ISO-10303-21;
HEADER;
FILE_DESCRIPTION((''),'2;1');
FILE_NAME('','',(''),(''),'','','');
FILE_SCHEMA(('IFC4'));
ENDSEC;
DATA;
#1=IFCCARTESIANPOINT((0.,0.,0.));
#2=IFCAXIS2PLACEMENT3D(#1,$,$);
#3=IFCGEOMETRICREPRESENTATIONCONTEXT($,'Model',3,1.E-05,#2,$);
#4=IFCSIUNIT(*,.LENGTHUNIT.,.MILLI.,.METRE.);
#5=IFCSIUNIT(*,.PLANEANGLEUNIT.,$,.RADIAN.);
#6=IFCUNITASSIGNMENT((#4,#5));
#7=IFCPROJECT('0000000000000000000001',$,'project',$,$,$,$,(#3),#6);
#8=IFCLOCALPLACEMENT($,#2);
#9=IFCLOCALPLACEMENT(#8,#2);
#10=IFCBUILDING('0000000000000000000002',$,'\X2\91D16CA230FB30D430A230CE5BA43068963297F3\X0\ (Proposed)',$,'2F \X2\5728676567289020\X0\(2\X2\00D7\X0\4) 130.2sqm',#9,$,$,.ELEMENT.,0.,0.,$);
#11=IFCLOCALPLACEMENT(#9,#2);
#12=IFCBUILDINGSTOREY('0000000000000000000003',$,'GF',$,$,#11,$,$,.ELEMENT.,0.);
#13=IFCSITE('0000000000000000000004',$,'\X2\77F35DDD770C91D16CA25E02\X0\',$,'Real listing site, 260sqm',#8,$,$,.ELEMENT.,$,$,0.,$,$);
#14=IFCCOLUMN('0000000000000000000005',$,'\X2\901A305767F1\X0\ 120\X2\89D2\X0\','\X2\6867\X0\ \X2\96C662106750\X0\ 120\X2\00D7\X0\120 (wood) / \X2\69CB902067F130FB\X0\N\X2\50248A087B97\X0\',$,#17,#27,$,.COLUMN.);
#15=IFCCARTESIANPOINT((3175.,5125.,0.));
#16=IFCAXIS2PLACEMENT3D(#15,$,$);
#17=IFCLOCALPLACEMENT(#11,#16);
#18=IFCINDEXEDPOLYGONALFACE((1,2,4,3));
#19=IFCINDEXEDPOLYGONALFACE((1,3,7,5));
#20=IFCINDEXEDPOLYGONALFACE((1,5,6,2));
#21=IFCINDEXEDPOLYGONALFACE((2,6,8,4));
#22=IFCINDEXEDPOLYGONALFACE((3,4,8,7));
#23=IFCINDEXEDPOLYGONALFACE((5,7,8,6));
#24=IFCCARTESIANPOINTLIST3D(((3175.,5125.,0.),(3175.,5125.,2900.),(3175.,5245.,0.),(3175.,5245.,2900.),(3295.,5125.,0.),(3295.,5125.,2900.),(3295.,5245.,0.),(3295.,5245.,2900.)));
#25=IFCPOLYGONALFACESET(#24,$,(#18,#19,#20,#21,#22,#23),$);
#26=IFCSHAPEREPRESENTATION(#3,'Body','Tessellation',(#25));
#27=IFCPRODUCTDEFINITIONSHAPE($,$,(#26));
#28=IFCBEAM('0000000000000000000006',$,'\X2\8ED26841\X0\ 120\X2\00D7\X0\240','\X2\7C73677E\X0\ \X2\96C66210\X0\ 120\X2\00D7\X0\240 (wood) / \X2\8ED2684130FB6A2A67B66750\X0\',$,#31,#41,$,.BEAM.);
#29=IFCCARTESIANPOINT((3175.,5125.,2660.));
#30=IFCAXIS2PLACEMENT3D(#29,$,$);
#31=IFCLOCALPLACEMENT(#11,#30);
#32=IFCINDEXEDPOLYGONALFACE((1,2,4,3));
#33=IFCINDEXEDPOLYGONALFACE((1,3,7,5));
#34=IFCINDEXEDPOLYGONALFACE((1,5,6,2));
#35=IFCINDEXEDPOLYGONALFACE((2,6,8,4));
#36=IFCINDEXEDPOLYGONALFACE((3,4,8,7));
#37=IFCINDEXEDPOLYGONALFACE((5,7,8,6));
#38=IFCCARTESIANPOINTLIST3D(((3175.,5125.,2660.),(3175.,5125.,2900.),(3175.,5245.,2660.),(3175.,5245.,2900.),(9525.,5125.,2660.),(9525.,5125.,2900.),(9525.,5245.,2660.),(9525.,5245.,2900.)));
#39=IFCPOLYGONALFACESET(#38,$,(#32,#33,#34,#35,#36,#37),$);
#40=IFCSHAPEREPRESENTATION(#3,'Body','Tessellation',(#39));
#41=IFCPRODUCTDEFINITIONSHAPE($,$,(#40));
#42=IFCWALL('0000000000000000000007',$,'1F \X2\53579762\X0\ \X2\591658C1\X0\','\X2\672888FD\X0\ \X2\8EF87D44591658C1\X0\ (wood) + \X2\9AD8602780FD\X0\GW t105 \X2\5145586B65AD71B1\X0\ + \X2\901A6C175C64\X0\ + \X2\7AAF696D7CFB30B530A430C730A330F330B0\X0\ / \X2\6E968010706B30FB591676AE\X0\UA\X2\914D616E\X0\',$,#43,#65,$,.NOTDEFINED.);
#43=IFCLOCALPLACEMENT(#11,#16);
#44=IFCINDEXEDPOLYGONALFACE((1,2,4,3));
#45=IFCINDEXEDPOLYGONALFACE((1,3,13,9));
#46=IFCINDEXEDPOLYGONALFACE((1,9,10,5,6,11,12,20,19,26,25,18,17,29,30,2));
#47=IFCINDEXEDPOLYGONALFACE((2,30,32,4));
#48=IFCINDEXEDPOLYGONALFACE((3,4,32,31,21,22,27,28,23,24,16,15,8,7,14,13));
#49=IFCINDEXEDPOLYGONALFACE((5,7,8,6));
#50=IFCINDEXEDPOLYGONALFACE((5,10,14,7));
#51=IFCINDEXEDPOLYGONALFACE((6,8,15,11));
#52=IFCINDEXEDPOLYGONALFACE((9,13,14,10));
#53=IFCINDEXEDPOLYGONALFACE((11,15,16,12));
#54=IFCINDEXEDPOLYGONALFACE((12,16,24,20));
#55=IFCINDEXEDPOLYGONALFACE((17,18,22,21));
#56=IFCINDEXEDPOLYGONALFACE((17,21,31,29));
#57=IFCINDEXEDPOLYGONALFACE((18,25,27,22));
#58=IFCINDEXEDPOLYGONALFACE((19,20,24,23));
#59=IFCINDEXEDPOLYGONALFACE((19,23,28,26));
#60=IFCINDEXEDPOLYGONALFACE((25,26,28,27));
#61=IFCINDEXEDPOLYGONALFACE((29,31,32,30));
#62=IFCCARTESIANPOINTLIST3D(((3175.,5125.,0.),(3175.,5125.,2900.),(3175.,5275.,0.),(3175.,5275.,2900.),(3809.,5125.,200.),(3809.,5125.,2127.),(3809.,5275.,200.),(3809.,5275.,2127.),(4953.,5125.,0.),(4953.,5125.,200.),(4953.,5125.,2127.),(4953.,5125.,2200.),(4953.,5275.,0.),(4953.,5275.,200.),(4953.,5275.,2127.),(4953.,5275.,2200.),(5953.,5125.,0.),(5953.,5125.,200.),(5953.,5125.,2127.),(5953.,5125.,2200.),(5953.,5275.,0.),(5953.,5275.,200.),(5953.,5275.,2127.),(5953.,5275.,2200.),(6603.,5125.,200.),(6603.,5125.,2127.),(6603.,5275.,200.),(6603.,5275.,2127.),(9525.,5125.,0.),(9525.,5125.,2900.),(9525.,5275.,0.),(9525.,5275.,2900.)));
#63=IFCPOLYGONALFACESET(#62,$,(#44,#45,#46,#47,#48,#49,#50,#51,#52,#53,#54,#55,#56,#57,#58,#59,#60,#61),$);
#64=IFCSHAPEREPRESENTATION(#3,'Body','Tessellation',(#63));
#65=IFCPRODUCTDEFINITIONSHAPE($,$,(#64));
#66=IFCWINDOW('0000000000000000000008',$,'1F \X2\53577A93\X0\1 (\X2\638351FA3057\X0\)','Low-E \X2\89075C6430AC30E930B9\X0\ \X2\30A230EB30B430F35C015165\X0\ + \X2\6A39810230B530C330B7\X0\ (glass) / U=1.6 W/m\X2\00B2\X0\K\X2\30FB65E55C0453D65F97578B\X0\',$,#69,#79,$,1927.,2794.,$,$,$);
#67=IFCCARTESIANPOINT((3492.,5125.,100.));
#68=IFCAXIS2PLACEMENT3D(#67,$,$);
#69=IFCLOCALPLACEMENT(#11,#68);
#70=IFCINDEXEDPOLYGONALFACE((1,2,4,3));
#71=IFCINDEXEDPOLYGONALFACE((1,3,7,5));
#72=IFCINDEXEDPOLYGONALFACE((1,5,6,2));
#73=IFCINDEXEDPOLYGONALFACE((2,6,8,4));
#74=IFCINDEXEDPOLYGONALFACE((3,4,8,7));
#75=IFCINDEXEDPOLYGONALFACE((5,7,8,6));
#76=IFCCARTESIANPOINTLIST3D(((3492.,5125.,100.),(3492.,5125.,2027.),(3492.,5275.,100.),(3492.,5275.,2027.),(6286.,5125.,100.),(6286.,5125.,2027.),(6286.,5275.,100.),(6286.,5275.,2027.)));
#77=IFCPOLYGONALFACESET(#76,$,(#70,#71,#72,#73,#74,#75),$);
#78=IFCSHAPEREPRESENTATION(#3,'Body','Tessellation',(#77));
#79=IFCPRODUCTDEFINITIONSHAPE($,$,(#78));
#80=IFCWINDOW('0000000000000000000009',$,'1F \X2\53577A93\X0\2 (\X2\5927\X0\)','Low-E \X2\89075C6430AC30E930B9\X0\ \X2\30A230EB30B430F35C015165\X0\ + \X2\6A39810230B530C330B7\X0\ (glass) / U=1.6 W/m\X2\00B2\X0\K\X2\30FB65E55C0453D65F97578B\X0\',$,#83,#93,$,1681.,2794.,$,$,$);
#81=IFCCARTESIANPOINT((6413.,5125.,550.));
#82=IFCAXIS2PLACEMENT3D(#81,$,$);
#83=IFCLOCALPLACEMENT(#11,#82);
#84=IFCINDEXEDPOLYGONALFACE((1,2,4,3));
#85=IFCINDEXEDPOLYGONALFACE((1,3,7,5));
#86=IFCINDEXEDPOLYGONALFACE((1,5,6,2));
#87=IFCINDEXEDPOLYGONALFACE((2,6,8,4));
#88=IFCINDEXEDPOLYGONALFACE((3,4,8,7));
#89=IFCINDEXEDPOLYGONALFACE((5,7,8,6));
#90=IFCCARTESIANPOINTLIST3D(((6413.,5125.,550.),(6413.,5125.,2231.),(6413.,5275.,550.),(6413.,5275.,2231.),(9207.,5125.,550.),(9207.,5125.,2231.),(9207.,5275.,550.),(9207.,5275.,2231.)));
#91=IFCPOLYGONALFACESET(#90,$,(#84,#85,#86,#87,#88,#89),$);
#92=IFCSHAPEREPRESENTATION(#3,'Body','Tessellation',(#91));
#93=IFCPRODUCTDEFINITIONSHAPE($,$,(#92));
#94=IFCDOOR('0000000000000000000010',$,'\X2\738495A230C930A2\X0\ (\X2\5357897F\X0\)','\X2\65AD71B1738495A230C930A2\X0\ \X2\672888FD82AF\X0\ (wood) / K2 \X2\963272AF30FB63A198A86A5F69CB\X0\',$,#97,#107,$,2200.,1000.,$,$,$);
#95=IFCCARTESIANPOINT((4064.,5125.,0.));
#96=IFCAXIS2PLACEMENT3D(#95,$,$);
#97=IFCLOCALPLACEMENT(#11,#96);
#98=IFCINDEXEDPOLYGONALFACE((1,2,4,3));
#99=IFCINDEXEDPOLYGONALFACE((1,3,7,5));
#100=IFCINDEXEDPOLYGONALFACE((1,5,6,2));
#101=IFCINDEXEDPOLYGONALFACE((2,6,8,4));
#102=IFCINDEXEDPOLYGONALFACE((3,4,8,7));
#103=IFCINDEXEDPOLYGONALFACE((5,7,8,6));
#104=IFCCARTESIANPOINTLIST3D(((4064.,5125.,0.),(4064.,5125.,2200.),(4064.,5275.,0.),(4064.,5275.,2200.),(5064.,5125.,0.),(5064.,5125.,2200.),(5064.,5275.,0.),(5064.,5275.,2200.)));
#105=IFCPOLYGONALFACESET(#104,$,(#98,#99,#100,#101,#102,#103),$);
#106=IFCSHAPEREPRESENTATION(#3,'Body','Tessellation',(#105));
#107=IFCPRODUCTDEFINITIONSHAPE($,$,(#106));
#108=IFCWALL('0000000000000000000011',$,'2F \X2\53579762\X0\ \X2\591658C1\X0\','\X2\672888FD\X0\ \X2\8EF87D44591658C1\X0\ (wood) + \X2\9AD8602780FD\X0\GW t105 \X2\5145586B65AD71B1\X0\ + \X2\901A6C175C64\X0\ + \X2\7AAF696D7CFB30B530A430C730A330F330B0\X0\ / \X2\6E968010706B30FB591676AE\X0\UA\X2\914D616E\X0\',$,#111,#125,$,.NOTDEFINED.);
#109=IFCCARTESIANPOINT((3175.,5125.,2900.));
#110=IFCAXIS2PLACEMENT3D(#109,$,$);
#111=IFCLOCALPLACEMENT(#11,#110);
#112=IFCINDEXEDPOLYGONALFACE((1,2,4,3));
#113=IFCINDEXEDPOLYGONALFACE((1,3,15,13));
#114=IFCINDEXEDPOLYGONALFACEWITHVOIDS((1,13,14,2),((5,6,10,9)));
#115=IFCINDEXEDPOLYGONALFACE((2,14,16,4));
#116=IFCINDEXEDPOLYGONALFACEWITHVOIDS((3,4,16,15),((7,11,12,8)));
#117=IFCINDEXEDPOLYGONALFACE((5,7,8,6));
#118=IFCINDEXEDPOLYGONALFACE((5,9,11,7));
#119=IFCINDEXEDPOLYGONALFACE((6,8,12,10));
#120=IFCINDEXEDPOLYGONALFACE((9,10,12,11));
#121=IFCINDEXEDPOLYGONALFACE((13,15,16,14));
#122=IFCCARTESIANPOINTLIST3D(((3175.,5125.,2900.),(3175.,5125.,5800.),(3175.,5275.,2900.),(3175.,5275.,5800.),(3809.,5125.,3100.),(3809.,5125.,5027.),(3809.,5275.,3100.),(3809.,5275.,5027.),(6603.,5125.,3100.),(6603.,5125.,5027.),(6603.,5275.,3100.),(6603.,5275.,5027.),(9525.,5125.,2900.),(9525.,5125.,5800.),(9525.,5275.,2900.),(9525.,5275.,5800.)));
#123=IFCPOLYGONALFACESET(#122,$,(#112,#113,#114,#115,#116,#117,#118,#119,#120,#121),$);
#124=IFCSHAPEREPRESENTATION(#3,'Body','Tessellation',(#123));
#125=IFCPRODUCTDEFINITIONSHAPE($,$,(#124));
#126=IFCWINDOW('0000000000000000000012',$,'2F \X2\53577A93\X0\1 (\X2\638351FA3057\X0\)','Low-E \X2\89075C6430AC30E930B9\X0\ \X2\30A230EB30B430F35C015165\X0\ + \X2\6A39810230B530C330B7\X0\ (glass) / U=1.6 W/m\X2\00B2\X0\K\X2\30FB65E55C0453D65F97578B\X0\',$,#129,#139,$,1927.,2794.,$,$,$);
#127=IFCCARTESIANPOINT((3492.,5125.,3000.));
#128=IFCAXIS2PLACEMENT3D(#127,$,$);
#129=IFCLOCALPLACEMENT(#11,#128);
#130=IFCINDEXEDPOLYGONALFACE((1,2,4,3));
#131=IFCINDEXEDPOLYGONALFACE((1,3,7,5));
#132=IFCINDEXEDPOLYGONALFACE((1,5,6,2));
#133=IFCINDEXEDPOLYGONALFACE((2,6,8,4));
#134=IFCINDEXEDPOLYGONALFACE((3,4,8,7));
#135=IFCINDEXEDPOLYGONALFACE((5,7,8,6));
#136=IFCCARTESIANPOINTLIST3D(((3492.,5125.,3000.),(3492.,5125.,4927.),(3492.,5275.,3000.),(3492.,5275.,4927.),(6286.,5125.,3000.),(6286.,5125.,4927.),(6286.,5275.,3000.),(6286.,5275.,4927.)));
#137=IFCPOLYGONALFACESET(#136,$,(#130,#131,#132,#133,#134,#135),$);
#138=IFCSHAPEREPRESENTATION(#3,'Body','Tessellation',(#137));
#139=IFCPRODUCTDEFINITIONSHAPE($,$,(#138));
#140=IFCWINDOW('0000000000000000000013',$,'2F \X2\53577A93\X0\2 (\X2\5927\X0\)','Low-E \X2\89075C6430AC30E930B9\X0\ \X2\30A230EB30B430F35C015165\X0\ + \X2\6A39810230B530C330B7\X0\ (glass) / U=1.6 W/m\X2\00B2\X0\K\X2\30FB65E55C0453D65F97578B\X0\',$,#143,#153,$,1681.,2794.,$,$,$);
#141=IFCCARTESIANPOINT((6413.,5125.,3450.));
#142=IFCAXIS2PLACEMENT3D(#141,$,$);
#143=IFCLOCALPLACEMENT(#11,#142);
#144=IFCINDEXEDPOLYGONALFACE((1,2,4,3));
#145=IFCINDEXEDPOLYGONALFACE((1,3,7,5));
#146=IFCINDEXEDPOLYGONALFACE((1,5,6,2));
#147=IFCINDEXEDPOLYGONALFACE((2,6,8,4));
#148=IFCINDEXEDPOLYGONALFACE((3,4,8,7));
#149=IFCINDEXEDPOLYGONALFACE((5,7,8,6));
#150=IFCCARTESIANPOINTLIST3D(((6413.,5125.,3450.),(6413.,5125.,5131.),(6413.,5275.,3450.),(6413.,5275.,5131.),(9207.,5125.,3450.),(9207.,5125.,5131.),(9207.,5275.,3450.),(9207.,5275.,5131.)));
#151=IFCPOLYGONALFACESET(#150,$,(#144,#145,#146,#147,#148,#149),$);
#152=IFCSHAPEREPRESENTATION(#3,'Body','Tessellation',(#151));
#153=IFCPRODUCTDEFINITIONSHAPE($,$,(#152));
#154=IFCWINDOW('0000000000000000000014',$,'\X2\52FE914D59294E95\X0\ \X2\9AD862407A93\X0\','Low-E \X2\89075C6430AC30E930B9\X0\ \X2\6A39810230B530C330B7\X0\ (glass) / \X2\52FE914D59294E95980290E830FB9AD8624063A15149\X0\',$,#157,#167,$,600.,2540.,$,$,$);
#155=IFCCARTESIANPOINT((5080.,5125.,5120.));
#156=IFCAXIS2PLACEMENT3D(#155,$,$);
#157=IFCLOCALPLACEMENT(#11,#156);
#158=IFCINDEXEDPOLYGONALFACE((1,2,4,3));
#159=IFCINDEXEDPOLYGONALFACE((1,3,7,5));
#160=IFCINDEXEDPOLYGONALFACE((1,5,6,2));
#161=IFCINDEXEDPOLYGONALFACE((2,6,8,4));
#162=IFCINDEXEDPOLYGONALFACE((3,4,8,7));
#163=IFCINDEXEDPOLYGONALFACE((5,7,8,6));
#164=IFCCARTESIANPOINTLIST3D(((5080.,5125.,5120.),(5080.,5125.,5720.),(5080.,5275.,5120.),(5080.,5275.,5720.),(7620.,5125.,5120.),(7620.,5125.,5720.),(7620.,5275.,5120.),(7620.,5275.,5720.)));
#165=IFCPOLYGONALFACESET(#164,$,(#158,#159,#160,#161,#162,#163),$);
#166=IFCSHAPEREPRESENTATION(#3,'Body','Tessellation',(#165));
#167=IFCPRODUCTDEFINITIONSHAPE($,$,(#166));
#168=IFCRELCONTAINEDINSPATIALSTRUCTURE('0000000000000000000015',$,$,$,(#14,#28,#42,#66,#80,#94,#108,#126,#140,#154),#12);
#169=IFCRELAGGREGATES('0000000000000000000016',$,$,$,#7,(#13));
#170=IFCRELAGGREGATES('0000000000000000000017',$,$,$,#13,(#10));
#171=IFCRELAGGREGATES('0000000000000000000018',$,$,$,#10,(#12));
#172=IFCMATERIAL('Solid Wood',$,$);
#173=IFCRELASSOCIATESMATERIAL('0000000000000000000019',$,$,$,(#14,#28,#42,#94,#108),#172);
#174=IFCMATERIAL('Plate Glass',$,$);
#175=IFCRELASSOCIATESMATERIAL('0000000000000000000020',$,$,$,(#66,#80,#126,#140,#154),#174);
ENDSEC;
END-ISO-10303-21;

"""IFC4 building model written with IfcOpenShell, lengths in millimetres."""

from ifc_helpers import new_model, si_unit, frame, frame_2d, origin, place, context, project, spatial, rectangle, extrude, material, element, fill, save


model = new_model("IFC4")

# Units and contexts
model_context = context("Model", 3, precision=1e-05, world=origin())
ifc_project = project(units=[si_unit("LENGTHUNIT", "METRE", prefix="MILLI"), si_unit("PLANEANGLEUNIT", "RADIAN")], contexts=[model_context])

# Site, building, storey
site_placement = place(None, origin())
site = spatial("IfcSite", under=ifc_project, at=site_placement, Name="石川県金沢市", ObjectType="Real listing site, 260sqm", CompositionType="ELEMENT", RefElevation=0.0)
building_placement = place(site_placement, origin())
building = spatial("IfcBuilding", under=site, at=building_placement, Name="金沢・ピアノ室と防音 (Proposed)", ObjectType="2F 在来木造(2×4) 130.2sqm", CompositionType="ELEMENT", ElevationOfRefHeight=0.0, ElevationOfTerrain=0.0)
storey_placement = place(building_placement, origin())
storey = spatial("IfcBuildingStorey", under=building, at=storey_placement, Name="GF", CompositionType="ELEMENT", Elevation=0.0)

# Column
ifc_material_1 = material(Name="Solid Wood")
column_placement = place(storey_placement, frame((3175.0, 5125.0, 0.0)))
element("IfcColumn", 1, at=column_placement, inside=storey, material=ifc_material_1, Name="通し柱 120角", Description="桧 集成材 120×120 (wood) / 構造柱・N値計算", PredefinedType="COLUMN", context=model_context, shape_type="SweptSolid", body=[
    extrude(rectangle(XDim=120.0, YDim=120.0, at=frame_2d((60.0, 60.0))), frame((3175.0, 5125.0, 0.0)), (0.0, 0.0, 1.0), 2900.0),
])

# Beam
beam_1_placement = place(storey_placement, frame((3175.0, 5125.0, 2660.0)))
element("IfcBeam", 2, at=beam_1_placement, inside=storey, material=ifc_material_1, Name="軒桁 120×240", Description="米松 集成 120×240 (wood) / 軒桁・横架材", PredefinedType="BEAM", context=model_context, shape_type="SweptSolid", body=[
    extrude(rectangle(XDim=6350.0, YDim=120.0, at=frame_2d((3175.0, 60.0))), frame((3175.0, 5125.0, 2660.0)), (0.0, 0.0, 1.0), 240.0),
])

# Wall, openings, windows, door
wall_1_placement = place(storey_placement, frame((3175.0, 5125.0, 0.0)))
wall_1 = element("IfcWall", 3, at=wall_1_placement, inside=storey, material=ifc_material_1, Name="1F 南面 外壁", Description="木製 軸組外壁 (wood) + 高性能GW t105 充填断熱 + 通気層 + 窯業系サイディング / 準耐火・外皮UA配慮", PredefinedType="NOTDEFINED", context=model_context, shape_type="SweptSolid", body=[
    extrude(rectangle(XDim=6350.0, YDim=150.0, at=frame_2d((3175.0, 75.0))), frame((3175.0, 5125.0, 0.0)), (0.0, 0.0, 1.0), 2900.0),
])
opening_1_placement = place(storey_placement, frame((3492.0, 5125.0, 100.0)))
opening_1 = element("IfcOpeningElement", 4, at=opening_1_placement, cuts=wall_1, PredefinedType="NOTDEFINED", context=model_context, shape_type="SweptSolid", body=[
    extrude(rectangle(XDim=2794.0, YDim=150.0, at=frame_2d((1397.0, 75.0))), frame((3492.0, 5125.0, 100.0)), (0.0, 0.0, 1.0), 1927.0),
])
opening_2_placement = place(storey_placement, frame((6413.0, 5125.0, 550.0)))
opening_2 = element("IfcOpeningElement", 5, at=opening_2_placement, cuts=wall_1, PredefinedType="NOTDEFINED", context=model_context, shape_type="SweptSolid", body=[
    extrude(rectangle(XDim=2794.0, YDim=150.0, at=frame_2d((1397.0, 75.0))), frame((6413.0, 5125.0, 550.0)), (0.0, 0.0, 1.0), 1681.0),
])
opening_3_placement = place(storey_placement, frame((4064.0, 5125.0, 0.0)))
opening_3 = element("IfcOpeningElement", 6, at=opening_3_placement, cuts=wall_1, PredefinedType="NOTDEFINED", context=model_context, shape_type="SweptSolid", body=[
    extrude(rectangle(XDim=1000.0, YDim=150.0, at=frame_2d((500.0, 75.0))), frame((4064.0, 5125.0, 0.0)), (0.0, 0.0, 1.0), 2200.0),
])
ifc_material_2 = material(Name="Plate Glass")
window_1_placement = place(storey_placement, frame((3492.0, 5125.0, 100.0)))
window_1 = element("IfcWindow", 7, at=window_1_placement, inside=storey, material=ifc_material_2, Name="1F 南窓1 (掃出し)", Description="Low-E 複層ガラス アルゴン封入 + 樹脂サッシ (glass) / U=1.6 W/m²K・日射取得型", OverallHeight=1927.0, OverallWidth=2794.0, context=model_context, shape_type="SweptSolid", body=[
    extrude(rectangle(XDim=2794.0, YDim=150.0, at=frame_2d((1397.0, 75.0))), frame((3492.0, 5125.0, 100.0)), (0.0, 0.0, 1.0), 1927.0),
])
fill(opening_1, window_1)
window_2_placement = place(storey_placement, frame((6413.0, 5125.0, 550.0)))
window_2 = element("IfcWindow", 8, at=window_2_placement, inside=storey, material=ifc_material_2, Name="1F 南窓2 (大)", Description="Low-E 複層ガラス アルゴン封入 + 樹脂サッシ (glass) / U=1.6 W/m²K・日射取得型", OverallHeight=1681.0, OverallWidth=2794.0, context=model_context, shape_type="SweptSolid", body=[
    extrude(rectangle(XDim=2794.0, YDim=150.0, at=frame_2d((1397.0, 75.0))), frame((6413.0, 5125.0, 550.0)), (0.0, 0.0, 1.0), 1681.0),
])
fill(opening_2, window_2)
door_placement = place(storey_placement, frame((4064.0, 5125.0, 0.0)))
door = element("IfcDoor", 9, at=door_placement, inside=storey, material=ifc_material_1, Name="玄関ドア (南西)", Description="断熱玄関ドア 木製芯 (wood) / K2 防犯・採風機構", OverallHeight=2200.0, OverallWidth=1000.0, context=model_context, shape_type="SweptSolid", body=[
    extrude(rectangle(XDim=1000.0, YDim=150.0, at=frame_2d((500.0, 75.0))), frame((4064.0, 5125.0, 0.0)), (0.0, 0.0, 1.0), 2200.0),
])
fill(opening_3, door)

# Wall, openings, windows
wall_2_placement = place(storey_placement, frame((3175.0, 5125.0, 2900.0)))
wall_2 = element("IfcWall", 10, at=wall_2_placement, inside=storey, material=ifc_material_1, Name="2F 南面 外壁", Description="木製 軸組外壁 (wood) + 高性能GW t105 充填断熱 + 通気層 + 窯業系サイディング / 準耐火・外皮UA配慮", PredefinedType="NOTDEFINED", context=model_context, shape_type="SweptSolid", body=[
    extrude(rectangle(XDim=6350.0, YDim=150.0, at=frame_2d((3175.0, 75.0))), frame((3175.0, 5125.0, 2900.0)), (0.0, 0.0, 1.0), 2900.0),
])
opening_4_placement = place(storey_placement, frame((3492.0, 5125.0, 3000.0)))
opening_4 = element("IfcOpeningElement", 11, at=opening_4_placement, cuts=wall_2, PredefinedType="NOTDEFINED", context=model_context, shape_type="SweptSolid", body=[
    extrude(rectangle(XDim=2794.0, YDim=150.0, at=frame_2d((1397.0, 75.0))), frame((3492.0, 5125.0, 3000.0)), (0.0, 0.0, 1.0), 1927.0),
])
opening_5_placement = place(storey_placement, frame((6413.0, 5125.0, 3450.0)))
opening_5 = element("IfcOpeningElement", 12, at=opening_5_placement, cuts=wall_2, PredefinedType="NOTDEFINED", context=model_context, shape_type="SweptSolid", body=[
    extrude(rectangle(XDim=2794.0, YDim=150.0, at=frame_2d((1397.0, 75.0))), frame((6413.0, 5125.0, 3450.0)), (0.0, 0.0, 1.0), 1681.0),
])
opening_6_placement = place(storey_placement, frame((5080.0, 5125.0, 5120.0)))
opening_6 = element("IfcOpeningElement", 13, at=opening_6_placement, cuts=wall_2, PredefinedType="NOTDEFINED", context=model_context, shape_type="SweptSolid", body=[
    extrude(rectangle(XDim=2540.0, YDim=150.0, at=frame_2d((1270.0, 75.0))), frame((5080.0, 5125.0, 5120.0)), (0.0, 0.0, 1.0), 600.0),
])
window_3_placement = place(storey_placement, frame((3492.0, 5125.0, 3000.0)))
window_3 = element("IfcWindow", 14, at=window_3_placement, inside=storey, material=ifc_material_2, Name="2F 南窓1 (掃出し)", Description="Low-E 複層ガラス アルゴン封入 + 樹脂サッシ (glass) / U=1.6 W/m²K・日射取得型", OverallHeight=1927.0, OverallWidth=2794.0, context=model_context, shape_type="SweptSolid", body=[
    extrude(rectangle(XDim=2794.0, YDim=150.0, at=frame_2d((1397.0, 75.0))), frame((3492.0, 5125.0, 3000.0)), (0.0, 0.0, 1.0), 1927.0),
])
fill(opening_4, window_3)
window_4_placement = place(storey_placement, frame((6413.0, 5125.0, 3450.0)))
window_4 = element("IfcWindow", 15, at=window_4_placement, inside=storey, material=ifc_material_2, Name="2F 南窓2 (大)", Description="Low-E 複層ガラス アルゴン封入 + 樹脂サッシ (glass) / U=1.6 W/m²K・日射取得型", OverallHeight=1681.0, OverallWidth=2794.0, context=model_context, shape_type="SweptSolid", body=[
    extrude(rectangle(XDim=2794.0, YDim=150.0, at=frame_2d((1397.0, 75.0))), frame((6413.0, 5125.0, 3450.0)), (0.0, 0.0, 1.0), 1681.0),
])
fill(opening_5, window_4)
window_5_placement = place(storey_placement, frame((5080.0, 5125.0, 5120.0)))
window_5 = element("IfcWindow", 16, at=window_5_placement, inside=storey, material=ifc_material_2, Name="勾配天井 高所窓", Description="Low-E 複層ガラス 樹脂サッシ (glass) / 勾配天井頂部・高所採光", OverallHeight=600.0, OverallWidth=2540.0, context=model_context, shape_type="SweptSolid", body=[
    extrude(rectangle(XDim=2540.0, YDim=150.0, at=frame_2d((1270.0, 75.0))), frame((5080.0, 5125.0, 5120.0)), (0.0, 0.0, 1.0), 600.0),
])
fill(opening_6, window_5)

save(model, "model.ifc")
